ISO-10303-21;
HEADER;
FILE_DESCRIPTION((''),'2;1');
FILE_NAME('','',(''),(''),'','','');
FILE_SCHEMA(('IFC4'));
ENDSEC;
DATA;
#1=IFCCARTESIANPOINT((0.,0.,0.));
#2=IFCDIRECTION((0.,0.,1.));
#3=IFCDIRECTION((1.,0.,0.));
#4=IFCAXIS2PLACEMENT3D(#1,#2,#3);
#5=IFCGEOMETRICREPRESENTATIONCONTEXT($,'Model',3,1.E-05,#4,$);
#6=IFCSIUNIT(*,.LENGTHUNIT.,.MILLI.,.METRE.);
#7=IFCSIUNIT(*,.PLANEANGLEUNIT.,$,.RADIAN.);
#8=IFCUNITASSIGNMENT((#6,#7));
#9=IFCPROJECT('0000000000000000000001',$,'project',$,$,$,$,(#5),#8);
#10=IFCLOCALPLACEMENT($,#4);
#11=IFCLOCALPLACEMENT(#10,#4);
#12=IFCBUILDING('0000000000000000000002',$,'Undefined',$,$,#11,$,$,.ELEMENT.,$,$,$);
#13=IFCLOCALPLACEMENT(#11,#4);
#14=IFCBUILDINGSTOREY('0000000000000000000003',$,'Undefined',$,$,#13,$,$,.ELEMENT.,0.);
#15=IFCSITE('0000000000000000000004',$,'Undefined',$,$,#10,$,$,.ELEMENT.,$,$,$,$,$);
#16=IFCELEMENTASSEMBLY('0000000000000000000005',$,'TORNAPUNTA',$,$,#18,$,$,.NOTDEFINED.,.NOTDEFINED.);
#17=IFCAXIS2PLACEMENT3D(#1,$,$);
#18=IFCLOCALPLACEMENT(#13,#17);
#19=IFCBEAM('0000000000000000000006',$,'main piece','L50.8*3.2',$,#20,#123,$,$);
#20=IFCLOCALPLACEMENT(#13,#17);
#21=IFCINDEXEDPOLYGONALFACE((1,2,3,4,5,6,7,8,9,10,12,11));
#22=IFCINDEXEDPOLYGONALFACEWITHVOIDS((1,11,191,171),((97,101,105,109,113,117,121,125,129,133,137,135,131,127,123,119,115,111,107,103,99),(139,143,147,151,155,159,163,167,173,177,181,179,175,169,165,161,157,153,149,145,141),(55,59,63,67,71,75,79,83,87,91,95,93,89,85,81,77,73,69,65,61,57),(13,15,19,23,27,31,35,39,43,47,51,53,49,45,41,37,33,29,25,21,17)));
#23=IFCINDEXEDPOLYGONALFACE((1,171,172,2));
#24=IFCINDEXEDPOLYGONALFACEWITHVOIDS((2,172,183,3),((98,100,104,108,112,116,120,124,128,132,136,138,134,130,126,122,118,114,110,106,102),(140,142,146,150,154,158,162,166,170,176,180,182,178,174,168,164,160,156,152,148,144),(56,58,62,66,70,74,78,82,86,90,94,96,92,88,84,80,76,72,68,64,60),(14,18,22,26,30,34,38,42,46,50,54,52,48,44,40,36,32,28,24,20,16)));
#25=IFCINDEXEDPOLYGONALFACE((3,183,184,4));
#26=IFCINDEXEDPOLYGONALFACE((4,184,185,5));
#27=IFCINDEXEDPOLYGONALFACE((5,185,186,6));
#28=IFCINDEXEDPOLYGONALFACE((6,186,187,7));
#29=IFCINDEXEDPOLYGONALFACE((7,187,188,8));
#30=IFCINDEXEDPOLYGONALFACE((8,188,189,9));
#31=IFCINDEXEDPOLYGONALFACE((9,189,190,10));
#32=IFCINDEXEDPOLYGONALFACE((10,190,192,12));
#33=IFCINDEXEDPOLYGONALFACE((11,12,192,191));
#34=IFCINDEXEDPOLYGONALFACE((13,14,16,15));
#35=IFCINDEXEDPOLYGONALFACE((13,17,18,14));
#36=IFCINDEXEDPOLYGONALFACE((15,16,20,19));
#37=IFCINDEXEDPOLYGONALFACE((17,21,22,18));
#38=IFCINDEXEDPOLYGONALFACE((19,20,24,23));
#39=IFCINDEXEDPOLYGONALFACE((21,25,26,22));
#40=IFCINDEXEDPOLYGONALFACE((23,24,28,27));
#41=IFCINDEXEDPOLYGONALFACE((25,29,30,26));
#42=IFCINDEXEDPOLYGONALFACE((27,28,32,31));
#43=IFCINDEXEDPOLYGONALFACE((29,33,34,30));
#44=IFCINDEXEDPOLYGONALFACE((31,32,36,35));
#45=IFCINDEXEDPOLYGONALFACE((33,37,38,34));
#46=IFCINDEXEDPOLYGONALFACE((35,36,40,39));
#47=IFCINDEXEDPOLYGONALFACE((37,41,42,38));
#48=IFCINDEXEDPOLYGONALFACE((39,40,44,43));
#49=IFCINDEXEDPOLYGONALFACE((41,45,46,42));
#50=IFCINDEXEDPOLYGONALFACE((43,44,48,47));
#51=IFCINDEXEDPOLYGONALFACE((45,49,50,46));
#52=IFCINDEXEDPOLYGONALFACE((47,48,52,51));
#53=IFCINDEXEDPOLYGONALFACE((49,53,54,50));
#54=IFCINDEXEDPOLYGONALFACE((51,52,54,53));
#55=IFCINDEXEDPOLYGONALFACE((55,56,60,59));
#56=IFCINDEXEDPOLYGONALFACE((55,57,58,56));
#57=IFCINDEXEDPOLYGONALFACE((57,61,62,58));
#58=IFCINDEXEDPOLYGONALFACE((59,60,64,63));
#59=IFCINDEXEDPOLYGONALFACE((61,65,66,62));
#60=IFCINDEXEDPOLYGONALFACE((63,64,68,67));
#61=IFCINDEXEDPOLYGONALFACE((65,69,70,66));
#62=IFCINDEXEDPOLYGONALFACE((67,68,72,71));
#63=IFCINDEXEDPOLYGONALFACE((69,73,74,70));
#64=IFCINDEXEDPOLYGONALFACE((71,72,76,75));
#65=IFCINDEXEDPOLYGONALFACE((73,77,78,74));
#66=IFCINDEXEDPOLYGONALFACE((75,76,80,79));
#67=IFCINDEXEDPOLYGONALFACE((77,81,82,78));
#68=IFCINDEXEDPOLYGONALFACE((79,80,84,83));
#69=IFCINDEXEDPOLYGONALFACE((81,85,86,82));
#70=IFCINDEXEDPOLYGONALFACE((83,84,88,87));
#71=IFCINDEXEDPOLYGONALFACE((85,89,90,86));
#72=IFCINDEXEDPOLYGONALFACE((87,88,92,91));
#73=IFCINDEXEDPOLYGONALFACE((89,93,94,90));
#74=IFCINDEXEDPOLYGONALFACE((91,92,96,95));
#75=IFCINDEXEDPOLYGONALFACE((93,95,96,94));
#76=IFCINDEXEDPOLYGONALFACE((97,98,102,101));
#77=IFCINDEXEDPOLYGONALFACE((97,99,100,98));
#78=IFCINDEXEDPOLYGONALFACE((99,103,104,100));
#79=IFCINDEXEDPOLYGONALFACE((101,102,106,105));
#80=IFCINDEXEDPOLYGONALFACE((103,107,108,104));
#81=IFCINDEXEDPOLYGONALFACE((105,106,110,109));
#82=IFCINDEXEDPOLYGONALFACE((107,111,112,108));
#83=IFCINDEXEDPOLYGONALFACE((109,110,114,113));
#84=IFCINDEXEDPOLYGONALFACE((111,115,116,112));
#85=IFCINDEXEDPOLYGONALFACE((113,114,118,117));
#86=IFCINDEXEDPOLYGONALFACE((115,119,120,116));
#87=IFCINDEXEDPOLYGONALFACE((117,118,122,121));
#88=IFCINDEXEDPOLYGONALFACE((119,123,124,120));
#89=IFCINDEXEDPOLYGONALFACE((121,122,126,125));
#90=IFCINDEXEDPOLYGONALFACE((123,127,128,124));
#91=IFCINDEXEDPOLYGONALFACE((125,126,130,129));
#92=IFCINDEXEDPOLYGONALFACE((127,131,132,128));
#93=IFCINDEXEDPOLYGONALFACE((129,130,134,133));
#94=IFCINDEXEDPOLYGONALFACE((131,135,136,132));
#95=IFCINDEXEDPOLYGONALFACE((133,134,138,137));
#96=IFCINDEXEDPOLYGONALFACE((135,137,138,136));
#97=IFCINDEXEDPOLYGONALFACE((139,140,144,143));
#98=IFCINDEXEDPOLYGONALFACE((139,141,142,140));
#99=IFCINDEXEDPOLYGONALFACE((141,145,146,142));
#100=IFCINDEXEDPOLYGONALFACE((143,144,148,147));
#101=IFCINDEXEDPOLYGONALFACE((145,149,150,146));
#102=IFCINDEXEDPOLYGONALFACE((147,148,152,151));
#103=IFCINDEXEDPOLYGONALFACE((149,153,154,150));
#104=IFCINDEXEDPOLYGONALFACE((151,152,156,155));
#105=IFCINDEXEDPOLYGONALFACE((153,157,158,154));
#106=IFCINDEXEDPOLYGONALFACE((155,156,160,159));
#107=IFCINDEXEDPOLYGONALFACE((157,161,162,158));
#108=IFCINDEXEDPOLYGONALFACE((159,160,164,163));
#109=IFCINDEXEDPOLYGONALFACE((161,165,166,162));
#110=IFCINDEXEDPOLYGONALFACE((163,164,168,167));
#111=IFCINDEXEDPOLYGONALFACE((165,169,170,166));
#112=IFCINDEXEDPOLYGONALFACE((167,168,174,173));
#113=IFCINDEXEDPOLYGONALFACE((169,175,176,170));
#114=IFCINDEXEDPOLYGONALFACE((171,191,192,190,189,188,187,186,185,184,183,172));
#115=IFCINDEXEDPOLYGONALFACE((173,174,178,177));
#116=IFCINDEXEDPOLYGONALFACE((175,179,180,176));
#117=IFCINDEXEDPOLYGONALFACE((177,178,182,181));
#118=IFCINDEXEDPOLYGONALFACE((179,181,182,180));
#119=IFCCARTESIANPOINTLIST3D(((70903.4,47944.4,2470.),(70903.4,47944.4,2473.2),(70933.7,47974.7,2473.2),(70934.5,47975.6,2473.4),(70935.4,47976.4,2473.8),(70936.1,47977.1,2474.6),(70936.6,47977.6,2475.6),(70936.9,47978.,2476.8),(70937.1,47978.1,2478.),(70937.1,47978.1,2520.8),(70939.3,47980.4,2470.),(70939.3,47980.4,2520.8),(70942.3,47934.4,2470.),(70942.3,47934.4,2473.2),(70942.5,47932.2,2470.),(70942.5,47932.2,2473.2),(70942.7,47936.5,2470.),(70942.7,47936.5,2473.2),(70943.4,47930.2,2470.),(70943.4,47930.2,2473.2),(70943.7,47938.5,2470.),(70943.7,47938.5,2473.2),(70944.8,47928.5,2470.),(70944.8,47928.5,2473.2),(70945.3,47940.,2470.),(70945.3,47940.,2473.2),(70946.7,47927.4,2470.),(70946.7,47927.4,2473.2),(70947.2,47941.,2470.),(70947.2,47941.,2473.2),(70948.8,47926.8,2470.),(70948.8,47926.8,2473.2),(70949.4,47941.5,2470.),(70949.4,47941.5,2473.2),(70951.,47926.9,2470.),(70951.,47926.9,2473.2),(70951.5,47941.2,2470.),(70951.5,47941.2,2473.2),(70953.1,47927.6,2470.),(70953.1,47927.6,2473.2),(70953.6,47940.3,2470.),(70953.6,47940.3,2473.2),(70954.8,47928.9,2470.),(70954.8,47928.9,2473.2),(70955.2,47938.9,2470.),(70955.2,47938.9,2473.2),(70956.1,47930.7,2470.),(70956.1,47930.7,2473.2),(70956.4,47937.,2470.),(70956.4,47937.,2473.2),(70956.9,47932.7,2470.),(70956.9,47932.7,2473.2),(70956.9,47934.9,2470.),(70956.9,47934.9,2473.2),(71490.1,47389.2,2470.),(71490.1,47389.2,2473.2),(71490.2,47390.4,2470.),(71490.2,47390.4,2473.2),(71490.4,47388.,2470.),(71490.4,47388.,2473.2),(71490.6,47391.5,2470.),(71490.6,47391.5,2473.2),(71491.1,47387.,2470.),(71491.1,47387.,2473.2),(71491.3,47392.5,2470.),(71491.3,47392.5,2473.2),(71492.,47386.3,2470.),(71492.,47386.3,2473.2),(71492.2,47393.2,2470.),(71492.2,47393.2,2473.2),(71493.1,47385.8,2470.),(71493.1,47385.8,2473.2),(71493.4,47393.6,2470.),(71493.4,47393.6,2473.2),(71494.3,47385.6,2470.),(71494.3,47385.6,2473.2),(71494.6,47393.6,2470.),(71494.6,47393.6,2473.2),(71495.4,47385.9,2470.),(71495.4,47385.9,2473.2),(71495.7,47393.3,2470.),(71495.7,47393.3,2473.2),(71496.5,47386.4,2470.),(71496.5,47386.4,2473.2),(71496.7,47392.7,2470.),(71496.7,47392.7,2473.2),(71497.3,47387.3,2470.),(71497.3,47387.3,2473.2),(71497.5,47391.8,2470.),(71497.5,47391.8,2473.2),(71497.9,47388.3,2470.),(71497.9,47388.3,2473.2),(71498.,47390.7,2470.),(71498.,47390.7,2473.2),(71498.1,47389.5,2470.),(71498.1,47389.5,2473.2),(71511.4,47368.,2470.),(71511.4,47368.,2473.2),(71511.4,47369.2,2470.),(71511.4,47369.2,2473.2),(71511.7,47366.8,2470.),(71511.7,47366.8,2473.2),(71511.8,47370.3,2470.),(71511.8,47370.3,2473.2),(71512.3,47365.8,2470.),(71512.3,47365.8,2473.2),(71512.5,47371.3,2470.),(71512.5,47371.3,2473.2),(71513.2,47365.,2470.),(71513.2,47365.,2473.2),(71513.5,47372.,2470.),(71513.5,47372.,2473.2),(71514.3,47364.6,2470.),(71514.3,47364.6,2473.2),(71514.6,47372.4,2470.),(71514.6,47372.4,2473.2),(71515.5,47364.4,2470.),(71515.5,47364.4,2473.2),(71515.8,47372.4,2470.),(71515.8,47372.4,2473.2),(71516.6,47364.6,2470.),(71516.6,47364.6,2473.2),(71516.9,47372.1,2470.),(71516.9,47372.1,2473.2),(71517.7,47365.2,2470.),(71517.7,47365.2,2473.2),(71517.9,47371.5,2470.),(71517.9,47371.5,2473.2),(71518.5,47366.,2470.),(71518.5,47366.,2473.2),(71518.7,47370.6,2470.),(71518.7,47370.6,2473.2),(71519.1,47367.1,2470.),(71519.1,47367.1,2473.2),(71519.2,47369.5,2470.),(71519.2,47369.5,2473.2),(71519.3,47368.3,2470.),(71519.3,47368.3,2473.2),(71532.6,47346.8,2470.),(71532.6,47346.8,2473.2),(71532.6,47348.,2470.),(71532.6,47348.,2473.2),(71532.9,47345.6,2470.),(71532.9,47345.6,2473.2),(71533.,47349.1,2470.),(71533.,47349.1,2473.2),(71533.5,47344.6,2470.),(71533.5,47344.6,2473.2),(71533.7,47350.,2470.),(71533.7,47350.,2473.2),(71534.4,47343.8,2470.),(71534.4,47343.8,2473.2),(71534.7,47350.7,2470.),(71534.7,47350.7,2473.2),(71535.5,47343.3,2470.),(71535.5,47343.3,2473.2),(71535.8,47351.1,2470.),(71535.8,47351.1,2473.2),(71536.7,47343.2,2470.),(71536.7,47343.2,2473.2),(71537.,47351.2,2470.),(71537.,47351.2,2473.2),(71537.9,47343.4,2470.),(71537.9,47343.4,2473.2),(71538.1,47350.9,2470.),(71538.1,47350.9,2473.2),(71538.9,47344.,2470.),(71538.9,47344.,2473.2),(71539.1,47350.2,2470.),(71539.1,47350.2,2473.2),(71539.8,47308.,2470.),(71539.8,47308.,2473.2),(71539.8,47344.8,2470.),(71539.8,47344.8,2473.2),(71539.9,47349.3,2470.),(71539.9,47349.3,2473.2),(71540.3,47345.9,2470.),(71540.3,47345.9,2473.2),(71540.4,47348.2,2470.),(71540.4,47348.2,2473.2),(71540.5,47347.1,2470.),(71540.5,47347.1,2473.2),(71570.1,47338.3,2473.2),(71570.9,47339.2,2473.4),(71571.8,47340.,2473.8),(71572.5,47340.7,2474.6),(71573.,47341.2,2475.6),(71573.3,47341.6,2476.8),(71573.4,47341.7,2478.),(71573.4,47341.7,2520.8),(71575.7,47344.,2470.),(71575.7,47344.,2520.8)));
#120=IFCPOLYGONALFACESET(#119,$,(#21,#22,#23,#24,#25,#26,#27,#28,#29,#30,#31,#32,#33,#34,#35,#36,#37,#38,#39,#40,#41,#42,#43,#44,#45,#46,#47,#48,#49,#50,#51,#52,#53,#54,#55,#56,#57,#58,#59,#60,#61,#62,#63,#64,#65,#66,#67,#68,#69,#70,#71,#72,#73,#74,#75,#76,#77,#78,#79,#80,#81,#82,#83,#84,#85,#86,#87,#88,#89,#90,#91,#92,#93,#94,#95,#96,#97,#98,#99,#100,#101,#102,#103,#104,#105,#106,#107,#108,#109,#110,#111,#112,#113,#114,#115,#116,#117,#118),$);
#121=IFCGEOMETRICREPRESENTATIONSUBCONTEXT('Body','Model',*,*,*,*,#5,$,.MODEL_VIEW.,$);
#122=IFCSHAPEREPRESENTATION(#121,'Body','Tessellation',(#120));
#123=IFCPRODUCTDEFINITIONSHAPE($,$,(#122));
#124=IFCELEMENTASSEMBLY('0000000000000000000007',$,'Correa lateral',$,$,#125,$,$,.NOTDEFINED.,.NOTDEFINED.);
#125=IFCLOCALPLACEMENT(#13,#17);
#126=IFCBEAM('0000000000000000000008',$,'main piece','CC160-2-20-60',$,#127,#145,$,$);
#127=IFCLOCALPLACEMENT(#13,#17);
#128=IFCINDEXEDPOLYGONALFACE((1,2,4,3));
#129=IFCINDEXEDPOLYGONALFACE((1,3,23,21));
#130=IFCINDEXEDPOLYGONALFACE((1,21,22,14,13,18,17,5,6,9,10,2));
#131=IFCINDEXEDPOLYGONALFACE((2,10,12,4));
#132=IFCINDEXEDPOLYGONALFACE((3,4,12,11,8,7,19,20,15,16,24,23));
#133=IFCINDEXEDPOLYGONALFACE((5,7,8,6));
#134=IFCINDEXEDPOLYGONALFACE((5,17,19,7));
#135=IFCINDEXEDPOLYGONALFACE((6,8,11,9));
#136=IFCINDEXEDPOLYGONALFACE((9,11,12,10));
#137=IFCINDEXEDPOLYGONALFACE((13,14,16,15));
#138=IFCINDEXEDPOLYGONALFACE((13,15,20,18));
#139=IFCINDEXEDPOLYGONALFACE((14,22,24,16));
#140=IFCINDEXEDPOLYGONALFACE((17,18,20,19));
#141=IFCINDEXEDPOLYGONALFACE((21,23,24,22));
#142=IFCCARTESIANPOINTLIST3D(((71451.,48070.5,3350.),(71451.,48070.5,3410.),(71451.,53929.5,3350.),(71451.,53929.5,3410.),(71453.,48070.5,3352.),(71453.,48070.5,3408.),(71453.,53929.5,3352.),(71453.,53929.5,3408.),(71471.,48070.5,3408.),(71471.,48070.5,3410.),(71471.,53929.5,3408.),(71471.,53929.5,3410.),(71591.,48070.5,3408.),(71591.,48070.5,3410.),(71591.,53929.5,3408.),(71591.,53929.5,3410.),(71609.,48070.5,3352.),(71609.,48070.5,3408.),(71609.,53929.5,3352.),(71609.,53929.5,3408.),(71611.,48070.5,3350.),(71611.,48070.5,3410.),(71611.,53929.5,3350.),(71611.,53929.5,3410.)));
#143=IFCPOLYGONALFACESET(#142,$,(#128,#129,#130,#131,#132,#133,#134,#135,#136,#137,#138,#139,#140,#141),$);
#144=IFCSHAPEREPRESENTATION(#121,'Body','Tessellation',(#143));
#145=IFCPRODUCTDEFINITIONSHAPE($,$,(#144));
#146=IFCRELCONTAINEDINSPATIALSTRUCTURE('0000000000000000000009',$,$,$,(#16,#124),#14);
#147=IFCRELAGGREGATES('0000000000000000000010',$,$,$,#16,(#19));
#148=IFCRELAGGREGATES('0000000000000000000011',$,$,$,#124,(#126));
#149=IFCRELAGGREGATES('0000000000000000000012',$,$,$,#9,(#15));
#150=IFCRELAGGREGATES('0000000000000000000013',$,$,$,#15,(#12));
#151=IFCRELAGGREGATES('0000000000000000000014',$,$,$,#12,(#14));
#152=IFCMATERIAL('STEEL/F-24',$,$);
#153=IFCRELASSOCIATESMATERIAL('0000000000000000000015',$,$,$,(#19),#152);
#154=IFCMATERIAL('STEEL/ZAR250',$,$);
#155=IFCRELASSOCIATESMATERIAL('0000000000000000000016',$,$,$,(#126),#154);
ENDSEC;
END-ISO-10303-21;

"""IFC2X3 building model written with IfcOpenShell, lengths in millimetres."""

from ifc_helpers import new_model, si_unit, frame, origin_with_axes, origin_2d_with_axis, place, context, subcontext, project, spatial, circle, l_section, c_section, extrude, source, transform, mapped, material, element, aggregate, save


model = new_model("IFC2X3")

# Units and contexts
model_context = context("Model", 3, precision=1e-05, world=origin_with_axes())
body_context = subcontext(model_context, "Body", "Model", "MODEL_VIEW")
ifc_project = project(units=[si_unit("LENGTHUNIT", "METRE", prefix="MILLI"), si_unit("PLANEANGLEUNIT", "RADIAN")], contexts=[model_context])

# Site, building, storey
site_placement = place(None, origin_with_axes())
site = spatial("IfcSite", under=ifc_project, at=site_placement, Name="Undefined", CompositionType="ELEMENT")
building_placement = place(site_placement, origin_with_axes())
building = spatial("IfcBuilding", under=site, at=building_placement, Name="Undefined", CompositionType="ELEMENT")
storey_placement = place(building_placement, origin_with_axes())
storey = spatial("IfcBuildingStorey", under=building, at=storey_placement, Name="Undefined", CompositionType="ELEMENT", Elevation=0.0)

# Element assembly, beam, openings
assembly_1_placement = place(storey_placement, origin_with_axes())
assembly_1 = element("IfcElementAssembly", 1, at=assembly_1_placement, inside=storey, Name="TORNAPUNTA", AssemblyPlace="NOTDEFINED", PredefinedType="NOTDEFINED")
ifc_material_1 = material(Name="STEEL/F-24")
beam_1_placement = place(assembly_1_placement, frame((70921.4, 47962.4, 2495.4), z_axis=(0.0, 0.0, 1.0), x_axis=(0.707107, -0.707107, 0.0)))
beam_1 = element("IfcBeam", 2, at=beam_1_placement, material=ifc_material_1, Name="main piece", Description="L50.8*3.2", context=body_context, shape_type="SweptSolid", body=[
    extrude(l_section(Depth=50.8, Width=50.8, Thickness=3.2, FilletRadius=4.8, at=origin_2d_with_axis()), frame((900.0, 0.0, 0.0), z_axis=(-1.0, 0.0, 0.0), x_axis=(0.0, -1.0, 0.0)), (0.0, 0.0, 1.0), 900.0),
])
shared_shape_1 = source(origin_with_axes(), body_context, "Body", "SweptSolid", [
    extrude(circle(Radius=4.0, at=origin_2d_with_axis()), frame((0.0, -3.3, 0.0), z_axis=(0.0, 1.0, 0.0), x_axis=(1.0, 0.0, 0.0)), (0.0, 0.0, 1.0), 3.4),
])
opening_1_placement = place(assembly_1_placement, frame((71536.5, 47347.2, 2470.0), z_axis=(-0.707107, -0.707107, 0.0), x_axis=(-0.707107, 0.707107, 0.0)))
element("IfcOpeningElement", 3, at=opening_1_placement, cuts=beam_1, ObjectType="Opening", context=body_context, shape_type="MappedRepresentation", body=[
    mapped(shared_shape_1, transform((0.0, 0.0, 0.0))),
    mapped(shared_shape_1, transform((30.0, 0.0, 0.0))),
    mapped(shared_shape_1, transform((60.0, 0.0, 0.0))),
])
shared_shape_2 = source(origin_with_axes(), body_context, "Body", "SweptSolid", [
    extrude(circle(Radius=7.3, at=origin_2d_with_axis()), frame((0.0, -3.3, 0.0), z_axis=(0.0, 1.0, 0.0), x_axis=(1.0, 0.0, 0.0)), (0.0, 0.0, 1.0), 3.4),
])
opening_2_placement = place(assembly_1_placement, frame((70949.6, 47934.1, 2470.0), z_axis=(0.707107, 0.707107, 0.0), x_axis=(0.707107, -0.707107, 0.0)))
element("IfcOpeningElement", 4, at=opening_2_placement, cuts=beam_1, ObjectType="Opening", context=body_context, shape_type="MappedRepresentation", body=[
    mapped(shared_shape_2, transform((0.0, 0.0, 0.0))),
])
aggregate(assembly_1, [beam_1])

# Element assembly, beam
assembly_2_placement = place(storey_placement, origin_with_axes())
assembly_2 = element("IfcElementAssembly", 5, at=assembly_2_placement, inside=storey, Name="Correa lateral", AssemblyPlace="NOTDEFINED", PredefinedType="NOTDEFINED")
ifc_material_2 = material(Name="STEEL/ZAR250")
beam_2_placement = place(assembly_2_placement, frame((71531.0, 48070.5, 3380.0), z_axis=(-1.0, 0.0, 0.0), x_axis=(0.0, 1.0, 0.0)))
beam_2 = element("IfcBeam", 6, at=beam_2_placement, material=ifc_material_2, Name="main piece", Description="CC160-2-20-60", context=body_context, shape_type="SweptSolid", body=[
    extrude(c_section(Depth=160.0, Width=60.0, WallThickness=2.0, Girth=20.0, at=origin_2d_with_axis()), frame((5859.0, 0.0, 0.0), z_axis=(-1.0, 0.0, 0.0), x_axis=(0.0, -1.0, 0.0)), (0.0, 0.0, 1.0), 5859.0),
])

aggregate(assembly_2, [beam_2])

save(model, "model.ifc")
